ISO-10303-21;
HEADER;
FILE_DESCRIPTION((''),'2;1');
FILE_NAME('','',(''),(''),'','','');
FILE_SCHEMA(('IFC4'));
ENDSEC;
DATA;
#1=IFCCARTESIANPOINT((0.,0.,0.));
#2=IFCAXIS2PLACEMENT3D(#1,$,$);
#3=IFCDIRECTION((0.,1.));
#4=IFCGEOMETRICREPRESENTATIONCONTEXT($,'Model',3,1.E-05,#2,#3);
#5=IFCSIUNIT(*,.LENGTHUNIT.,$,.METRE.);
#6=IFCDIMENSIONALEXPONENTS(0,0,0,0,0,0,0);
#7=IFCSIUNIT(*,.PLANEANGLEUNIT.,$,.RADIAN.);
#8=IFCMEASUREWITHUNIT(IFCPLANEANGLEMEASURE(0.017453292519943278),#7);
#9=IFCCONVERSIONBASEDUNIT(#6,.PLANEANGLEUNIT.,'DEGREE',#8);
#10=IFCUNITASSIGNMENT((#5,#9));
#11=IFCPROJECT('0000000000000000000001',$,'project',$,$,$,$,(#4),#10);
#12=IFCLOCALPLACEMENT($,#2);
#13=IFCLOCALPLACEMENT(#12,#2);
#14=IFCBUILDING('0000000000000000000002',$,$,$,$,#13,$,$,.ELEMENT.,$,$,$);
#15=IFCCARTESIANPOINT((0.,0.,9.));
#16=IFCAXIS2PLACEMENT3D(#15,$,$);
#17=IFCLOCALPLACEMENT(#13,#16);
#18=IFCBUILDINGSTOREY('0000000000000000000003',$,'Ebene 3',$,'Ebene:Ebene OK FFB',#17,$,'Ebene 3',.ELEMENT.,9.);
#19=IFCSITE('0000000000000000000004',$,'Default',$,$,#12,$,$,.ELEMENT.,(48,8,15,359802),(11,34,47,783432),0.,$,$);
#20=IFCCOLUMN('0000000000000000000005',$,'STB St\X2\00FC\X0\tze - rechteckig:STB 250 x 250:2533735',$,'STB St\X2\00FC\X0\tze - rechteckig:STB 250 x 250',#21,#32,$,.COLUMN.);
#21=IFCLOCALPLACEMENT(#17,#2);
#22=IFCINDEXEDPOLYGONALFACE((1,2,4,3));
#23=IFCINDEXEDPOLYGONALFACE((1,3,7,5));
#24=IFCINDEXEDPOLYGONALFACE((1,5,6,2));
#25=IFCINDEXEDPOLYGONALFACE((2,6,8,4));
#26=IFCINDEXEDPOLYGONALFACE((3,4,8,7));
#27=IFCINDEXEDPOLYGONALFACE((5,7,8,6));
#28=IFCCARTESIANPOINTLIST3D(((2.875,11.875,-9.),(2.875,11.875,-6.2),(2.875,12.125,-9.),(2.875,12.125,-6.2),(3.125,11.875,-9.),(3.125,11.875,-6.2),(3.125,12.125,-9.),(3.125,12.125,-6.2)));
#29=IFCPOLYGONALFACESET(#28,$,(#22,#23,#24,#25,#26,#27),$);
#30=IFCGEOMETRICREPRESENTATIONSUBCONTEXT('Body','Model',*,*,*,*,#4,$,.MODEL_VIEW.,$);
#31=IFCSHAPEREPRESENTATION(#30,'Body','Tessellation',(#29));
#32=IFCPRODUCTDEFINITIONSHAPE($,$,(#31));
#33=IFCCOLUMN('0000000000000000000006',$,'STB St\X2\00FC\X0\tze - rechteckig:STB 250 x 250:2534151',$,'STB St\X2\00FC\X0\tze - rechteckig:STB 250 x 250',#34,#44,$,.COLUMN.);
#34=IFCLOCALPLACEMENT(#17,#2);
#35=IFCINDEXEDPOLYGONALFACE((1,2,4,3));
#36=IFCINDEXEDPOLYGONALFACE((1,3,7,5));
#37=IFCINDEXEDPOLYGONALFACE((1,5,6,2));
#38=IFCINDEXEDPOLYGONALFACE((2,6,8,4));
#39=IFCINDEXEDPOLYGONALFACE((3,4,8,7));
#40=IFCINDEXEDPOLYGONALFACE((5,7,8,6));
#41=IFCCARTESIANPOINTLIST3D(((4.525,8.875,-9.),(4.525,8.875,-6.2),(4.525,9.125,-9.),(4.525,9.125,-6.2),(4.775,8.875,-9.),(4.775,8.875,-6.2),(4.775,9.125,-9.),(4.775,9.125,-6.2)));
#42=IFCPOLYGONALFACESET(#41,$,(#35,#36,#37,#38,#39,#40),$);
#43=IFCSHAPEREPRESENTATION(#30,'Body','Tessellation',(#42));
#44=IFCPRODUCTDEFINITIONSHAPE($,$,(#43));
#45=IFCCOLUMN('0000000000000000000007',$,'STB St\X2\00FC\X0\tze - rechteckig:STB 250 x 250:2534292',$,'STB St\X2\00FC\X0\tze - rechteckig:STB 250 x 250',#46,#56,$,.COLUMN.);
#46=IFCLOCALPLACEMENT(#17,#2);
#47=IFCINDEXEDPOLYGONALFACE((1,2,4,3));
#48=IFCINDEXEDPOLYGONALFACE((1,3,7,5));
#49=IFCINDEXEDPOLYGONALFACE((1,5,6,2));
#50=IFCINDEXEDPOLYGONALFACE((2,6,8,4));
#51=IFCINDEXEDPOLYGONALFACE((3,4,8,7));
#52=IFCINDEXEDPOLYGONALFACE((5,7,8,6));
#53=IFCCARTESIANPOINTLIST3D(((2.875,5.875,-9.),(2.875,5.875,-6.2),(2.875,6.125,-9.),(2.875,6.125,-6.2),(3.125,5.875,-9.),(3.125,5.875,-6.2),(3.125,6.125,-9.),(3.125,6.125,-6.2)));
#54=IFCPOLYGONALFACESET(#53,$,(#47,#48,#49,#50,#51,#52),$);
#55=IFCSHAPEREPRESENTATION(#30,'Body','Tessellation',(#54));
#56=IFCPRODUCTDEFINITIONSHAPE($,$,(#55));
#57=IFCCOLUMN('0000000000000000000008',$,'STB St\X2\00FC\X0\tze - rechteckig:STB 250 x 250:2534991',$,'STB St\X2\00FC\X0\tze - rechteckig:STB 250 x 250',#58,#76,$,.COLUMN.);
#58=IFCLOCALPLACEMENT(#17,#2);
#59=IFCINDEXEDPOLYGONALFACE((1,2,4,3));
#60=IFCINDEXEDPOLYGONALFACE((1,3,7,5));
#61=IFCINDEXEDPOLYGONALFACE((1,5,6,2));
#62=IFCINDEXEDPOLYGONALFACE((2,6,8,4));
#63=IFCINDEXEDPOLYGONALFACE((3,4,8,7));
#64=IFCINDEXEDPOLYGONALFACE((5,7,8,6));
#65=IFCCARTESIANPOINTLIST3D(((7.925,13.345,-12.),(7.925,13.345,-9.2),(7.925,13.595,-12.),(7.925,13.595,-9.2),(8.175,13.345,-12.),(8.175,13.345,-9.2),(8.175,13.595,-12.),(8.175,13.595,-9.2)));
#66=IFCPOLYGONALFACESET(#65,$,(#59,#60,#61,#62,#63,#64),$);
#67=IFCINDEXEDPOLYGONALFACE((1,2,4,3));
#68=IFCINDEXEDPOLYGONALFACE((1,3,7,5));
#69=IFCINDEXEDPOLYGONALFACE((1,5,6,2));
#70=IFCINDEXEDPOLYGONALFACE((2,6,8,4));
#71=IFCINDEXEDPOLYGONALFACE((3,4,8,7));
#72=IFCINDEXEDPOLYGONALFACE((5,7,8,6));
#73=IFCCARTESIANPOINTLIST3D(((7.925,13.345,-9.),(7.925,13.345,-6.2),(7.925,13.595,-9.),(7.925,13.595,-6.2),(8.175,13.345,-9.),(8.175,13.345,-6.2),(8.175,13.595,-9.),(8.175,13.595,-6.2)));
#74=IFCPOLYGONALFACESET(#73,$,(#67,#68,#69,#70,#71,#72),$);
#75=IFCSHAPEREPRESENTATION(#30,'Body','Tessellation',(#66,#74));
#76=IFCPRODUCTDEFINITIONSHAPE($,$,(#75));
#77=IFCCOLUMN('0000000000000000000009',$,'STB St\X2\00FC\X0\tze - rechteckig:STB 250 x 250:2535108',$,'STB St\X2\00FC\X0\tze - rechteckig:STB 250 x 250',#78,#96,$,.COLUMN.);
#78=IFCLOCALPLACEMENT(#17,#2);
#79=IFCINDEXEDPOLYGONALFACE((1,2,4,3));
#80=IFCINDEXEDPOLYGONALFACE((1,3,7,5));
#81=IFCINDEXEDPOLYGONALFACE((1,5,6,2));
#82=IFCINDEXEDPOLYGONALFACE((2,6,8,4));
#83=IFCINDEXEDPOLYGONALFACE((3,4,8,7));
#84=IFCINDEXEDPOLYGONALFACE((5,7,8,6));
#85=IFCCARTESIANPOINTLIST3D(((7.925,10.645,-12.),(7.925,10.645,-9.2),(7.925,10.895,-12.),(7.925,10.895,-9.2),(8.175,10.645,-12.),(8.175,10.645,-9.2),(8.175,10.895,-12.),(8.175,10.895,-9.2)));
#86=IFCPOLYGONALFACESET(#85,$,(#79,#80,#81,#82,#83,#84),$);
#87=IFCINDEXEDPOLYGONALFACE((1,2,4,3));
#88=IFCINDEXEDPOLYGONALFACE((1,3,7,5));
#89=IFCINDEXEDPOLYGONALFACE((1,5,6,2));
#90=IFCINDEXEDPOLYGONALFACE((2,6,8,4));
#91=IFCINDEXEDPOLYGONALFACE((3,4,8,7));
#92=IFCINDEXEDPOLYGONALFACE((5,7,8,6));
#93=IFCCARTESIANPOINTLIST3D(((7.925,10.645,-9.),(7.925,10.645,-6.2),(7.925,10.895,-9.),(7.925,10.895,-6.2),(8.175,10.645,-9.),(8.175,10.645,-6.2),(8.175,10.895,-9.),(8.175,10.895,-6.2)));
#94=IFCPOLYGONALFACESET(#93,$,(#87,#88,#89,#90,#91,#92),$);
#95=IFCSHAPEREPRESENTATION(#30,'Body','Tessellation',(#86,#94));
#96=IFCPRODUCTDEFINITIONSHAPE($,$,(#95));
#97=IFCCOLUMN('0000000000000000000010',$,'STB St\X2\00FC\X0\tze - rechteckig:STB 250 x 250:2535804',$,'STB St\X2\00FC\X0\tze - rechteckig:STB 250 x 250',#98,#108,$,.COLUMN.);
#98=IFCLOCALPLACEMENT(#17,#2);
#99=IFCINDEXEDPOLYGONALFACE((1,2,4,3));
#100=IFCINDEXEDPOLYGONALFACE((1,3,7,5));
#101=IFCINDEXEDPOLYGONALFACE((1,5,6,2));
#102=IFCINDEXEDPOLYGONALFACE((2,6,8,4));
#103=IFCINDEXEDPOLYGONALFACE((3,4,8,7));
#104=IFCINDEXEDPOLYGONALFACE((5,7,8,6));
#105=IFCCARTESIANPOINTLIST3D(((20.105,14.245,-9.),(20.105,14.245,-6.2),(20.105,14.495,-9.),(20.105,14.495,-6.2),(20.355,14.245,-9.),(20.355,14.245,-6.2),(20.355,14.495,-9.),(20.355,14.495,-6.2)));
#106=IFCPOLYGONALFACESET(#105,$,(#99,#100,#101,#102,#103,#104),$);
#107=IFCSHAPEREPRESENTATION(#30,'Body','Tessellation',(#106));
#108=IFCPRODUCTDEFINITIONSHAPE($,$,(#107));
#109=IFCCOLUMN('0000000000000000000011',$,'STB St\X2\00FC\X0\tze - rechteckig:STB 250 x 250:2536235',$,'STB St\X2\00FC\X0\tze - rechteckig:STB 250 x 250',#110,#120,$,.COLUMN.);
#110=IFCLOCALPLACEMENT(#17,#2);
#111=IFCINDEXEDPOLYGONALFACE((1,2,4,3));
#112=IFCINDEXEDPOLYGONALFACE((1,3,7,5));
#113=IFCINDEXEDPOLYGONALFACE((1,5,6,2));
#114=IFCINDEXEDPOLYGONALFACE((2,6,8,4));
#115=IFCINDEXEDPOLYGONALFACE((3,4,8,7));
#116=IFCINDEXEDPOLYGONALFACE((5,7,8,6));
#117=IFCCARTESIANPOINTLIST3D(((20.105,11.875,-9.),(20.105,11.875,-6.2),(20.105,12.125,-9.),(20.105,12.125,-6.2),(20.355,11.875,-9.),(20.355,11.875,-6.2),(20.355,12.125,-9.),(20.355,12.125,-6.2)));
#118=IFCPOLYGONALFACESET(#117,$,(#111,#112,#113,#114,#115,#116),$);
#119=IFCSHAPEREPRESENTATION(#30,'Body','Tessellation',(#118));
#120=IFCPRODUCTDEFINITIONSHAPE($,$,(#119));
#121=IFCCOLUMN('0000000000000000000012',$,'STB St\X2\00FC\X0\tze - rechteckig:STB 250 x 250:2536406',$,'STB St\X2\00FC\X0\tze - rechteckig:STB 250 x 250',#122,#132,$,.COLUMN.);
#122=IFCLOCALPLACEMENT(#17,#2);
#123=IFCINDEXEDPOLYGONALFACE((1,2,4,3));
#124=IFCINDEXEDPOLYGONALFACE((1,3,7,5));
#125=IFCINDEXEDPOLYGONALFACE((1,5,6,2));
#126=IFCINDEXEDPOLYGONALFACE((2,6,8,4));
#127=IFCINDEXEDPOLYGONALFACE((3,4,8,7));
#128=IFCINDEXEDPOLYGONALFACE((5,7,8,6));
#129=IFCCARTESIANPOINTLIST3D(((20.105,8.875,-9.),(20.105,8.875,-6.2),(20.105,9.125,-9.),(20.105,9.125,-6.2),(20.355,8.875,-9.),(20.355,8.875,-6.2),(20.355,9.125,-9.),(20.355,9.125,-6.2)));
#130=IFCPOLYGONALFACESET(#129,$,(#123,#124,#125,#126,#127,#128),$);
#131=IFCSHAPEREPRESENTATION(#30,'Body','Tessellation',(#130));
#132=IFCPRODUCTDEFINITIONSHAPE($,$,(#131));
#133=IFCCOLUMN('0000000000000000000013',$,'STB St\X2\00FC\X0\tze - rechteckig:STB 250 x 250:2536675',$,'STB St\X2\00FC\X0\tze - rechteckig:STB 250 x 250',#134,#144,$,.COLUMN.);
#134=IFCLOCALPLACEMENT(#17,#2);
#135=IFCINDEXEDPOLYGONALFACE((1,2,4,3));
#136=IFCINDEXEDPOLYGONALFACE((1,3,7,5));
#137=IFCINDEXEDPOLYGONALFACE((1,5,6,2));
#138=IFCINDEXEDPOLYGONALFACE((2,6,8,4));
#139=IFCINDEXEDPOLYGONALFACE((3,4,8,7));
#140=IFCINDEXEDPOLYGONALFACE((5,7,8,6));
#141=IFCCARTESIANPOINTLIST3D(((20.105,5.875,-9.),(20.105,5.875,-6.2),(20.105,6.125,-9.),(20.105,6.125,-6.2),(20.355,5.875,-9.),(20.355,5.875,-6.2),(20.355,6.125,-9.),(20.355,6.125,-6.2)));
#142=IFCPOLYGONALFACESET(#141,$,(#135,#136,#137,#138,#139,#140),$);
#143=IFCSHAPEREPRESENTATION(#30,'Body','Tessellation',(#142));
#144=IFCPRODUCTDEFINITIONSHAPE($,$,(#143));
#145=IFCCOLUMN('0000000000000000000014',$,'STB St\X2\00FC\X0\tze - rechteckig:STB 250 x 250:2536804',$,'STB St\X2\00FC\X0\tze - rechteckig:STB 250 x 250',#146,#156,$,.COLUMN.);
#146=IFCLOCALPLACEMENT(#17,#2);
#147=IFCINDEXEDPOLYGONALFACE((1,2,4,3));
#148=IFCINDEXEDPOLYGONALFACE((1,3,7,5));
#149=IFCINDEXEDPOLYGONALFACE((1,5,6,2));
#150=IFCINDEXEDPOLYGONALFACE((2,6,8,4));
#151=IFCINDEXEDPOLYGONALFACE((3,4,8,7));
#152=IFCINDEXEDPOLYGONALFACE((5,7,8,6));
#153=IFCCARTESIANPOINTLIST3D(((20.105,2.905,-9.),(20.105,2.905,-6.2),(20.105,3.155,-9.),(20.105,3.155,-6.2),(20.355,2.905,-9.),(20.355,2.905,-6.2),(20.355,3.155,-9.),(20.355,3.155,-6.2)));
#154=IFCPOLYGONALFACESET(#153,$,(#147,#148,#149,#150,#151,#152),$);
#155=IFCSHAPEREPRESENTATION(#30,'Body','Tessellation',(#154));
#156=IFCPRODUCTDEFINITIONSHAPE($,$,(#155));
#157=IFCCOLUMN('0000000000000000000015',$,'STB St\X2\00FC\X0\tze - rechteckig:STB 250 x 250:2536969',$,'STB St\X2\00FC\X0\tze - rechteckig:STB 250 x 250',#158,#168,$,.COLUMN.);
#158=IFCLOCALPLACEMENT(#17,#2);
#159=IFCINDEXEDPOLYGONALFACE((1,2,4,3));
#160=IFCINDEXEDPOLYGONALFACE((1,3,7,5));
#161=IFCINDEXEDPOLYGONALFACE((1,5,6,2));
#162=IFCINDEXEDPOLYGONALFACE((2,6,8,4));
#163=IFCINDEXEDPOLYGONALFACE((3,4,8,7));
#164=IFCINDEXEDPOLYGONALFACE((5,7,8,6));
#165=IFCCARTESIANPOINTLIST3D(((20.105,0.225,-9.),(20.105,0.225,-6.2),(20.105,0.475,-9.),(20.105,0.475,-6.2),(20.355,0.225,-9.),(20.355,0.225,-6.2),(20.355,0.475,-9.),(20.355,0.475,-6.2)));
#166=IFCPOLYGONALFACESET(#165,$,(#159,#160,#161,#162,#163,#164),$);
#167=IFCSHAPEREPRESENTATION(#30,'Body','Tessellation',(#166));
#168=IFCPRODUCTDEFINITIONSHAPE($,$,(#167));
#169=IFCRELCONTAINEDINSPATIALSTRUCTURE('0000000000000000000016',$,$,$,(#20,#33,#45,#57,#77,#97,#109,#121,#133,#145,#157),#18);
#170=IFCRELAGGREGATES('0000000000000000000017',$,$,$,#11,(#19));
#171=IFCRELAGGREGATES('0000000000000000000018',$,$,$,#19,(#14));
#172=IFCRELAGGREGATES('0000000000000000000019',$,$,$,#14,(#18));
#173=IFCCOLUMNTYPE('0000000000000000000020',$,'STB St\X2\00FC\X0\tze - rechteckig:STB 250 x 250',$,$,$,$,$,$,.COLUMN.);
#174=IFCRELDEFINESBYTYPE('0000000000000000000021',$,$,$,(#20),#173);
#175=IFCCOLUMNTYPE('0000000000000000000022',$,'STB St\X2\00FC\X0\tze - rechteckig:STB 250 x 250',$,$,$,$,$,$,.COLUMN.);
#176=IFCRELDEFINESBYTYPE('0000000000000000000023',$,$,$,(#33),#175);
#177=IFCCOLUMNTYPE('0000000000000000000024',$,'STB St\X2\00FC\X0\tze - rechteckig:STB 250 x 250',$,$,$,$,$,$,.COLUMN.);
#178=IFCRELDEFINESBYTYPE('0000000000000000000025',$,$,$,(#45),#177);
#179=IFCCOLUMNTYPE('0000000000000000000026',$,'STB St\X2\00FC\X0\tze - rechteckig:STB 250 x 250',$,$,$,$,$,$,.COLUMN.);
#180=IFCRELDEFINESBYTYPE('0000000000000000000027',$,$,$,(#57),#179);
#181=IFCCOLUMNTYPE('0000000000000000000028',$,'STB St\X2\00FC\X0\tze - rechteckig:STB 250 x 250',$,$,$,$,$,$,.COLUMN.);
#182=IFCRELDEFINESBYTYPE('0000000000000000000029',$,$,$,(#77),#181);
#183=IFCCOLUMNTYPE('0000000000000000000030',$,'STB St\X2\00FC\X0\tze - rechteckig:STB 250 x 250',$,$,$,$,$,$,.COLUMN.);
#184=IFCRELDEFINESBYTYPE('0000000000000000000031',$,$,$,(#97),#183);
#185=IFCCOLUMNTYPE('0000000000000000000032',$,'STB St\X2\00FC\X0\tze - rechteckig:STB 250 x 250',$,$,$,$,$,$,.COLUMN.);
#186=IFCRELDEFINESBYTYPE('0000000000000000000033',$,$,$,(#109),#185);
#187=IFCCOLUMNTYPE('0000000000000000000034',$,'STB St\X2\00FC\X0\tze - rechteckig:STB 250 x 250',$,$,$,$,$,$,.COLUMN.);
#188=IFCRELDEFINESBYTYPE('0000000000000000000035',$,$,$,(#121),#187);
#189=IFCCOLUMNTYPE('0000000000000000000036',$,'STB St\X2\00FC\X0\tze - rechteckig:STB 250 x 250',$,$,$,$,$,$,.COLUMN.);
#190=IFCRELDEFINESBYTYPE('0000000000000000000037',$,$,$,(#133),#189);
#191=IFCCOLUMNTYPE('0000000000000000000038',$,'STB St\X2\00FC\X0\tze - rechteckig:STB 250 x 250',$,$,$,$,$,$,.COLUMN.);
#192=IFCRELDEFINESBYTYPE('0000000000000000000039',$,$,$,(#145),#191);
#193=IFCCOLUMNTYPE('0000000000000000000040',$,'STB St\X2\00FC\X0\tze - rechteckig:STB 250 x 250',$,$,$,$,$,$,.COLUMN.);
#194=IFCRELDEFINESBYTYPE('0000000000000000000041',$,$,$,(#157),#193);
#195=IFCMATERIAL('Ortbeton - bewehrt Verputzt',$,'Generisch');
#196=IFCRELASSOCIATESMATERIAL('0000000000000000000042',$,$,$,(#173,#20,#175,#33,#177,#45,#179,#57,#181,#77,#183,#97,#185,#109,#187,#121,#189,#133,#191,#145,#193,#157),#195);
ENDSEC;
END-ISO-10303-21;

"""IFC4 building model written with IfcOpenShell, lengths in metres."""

from ifc_helpers import new_model, entity, si_unit, converted_unit, direction, frame, origin, place, context, subcontext, project, spatial, indexed_curve, outline, extrude, source, transform, mapped, material, type_object, type_shapes, element, save


model = new_model("IFC4")

# Units and contexts
model_context = context("Model", 3, precision=1e-05, world=origin(), true_north=direction((0.0, 1.0)))
body_context = subcontext(model_context, "Body", "Model", "MODEL_VIEW")
ifc_project = project(units=[si_unit("LENGTHUNIT", "METRE"), converted_unit("PLANEANGLEUNIT", "DEGREE", entity("IfcPlaneAngleMeasure", 0.017453292519943278), si_unit("PLANEANGLEUNIT", "RADIAN"), dimensions=[0, 0, 0, 0, 0, 0, 0])], contexts=[model_context])

# Site, building, storey
site_placement = place(None, origin())
site = spatial("IfcSite", under=ifc_project, at=site_placement, Name="Default", CompositionType="ELEMENT", RefLatitude=(48, 8, 15, 359802), RefLongitude=(11, 34, 47, 783432), RefElevation=0.0)
building_placement = place(site_placement, origin())
building = spatial("IfcBuilding", under=site, at=building_placement, CompositionType="ELEMENT")
storey_placement = place(building_placement, frame((0.0, 0.0, 9.0)))
storey = spatial("IfcBuildingStorey", under=building, at=storey_placement, Name="Ebene 3", ObjectType="Ebene:Ebene OK FFB", LongName="Ebene 3", CompositionType="ELEMENT", Elevation=9.0)

# Columns
ifc_material_1 = material(Name="Ortbeton - bewehrt Verputzt", Category="Generisch")
column_type_1 = type_object("IfcColumnType", Name="STB Stütze - rechteckig:STB 250 x 250", PredefinedType="COLUMN", material=ifc_material_1)
shared_shape_1 = source(origin(), body_context, "Body", "SweptSolid", [
    extrude(outline(indexed_curve([(-0.125, -0.125), (0.125, -0.125), (0.125, 0.125), (-0.125, 0.125), (-0.125, -0.125)], self_intersect=False)), frame((3.0, 12.0, 0.0), z_axis=(0.0, 0.0, 1.0), x_axis=(-1.0, 0.0, 0.0)), (0.0, 0.0, 1.0), 2.8),
])
type_shapes(column_type_1, [shared_shape_1])
column_1_placement = place(storey_placement, frame((0.0, 0.0, -9.0)))
element("IfcColumn", 1, at=column_1_placement, inside=storey, type_object=column_type_1, material=ifc_material_1, Name="STB Stütze - rechteckig:STB 250 x 250:2533735", ObjectType="STB Stütze - rechteckig:STB 250 x 250", PredefinedType="COLUMN", context=body_context, shape_type="MappedRepresentation", body=[
    mapped(shared_shape_1, transform((0.0, 0.0, 0.0), scale=1.0)),
])
column_type_2 = type_object("IfcColumnType", Name="STB Stütze - rechteckig:STB 250 x 250", PredefinedType="COLUMN", material=ifc_material_1)
shared_shape_2 = source(origin(), body_context, "Body", "SweptSolid", [
    extrude(outline(indexed_curve([(-0.125, -0.125), (0.125, -0.125), (0.125, 0.125), (-0.125, 0.125), (-0.125, -0.125)], self_intersect=False)), frame((4.65, 9.0, 0.0), z_axis=(0.0, 0.0, 1.0), x_axis=(-1.0, 0.0, 0.0)), (0.0, 0.0, 1.0), 2.8),
])
type_shapes(column_type_2, [shared_shape_2])
column_2_placement = place(storey_placement, frame((0.0, 0.0, -9.0)))
element("IfcColumn", 2, at=column_2_placement, inside=storey, type_object=column_type_2, material=ifc_material_1, Name="STB Stütze - rechteckig:STB 250 x 250:2534151", ObjectType="STB Stütze - rechteckig:STB 250 x 250", PredefinedType="COLUMN", context=body_context, shape_type="MappedRepresentation", body=[
    mapped(shared_shape_2, transform((0.0, 0.0, 0.0), scale=1.0)),
])
column_type_3 = type_object("IfcColumnType", Name="STB Stütze - rechteckig:STB 250 x 250", PredefinedType="COLUMN", material=ifc_material_1)
shared_shape_3 = source(origin(), body_context, "Body", "SweptSolid", [
    extrude(outline(indexed_curve([(-0.125, -0.125), (0.125, -0.125), (0.125, 0.125), (-0.125, 0.125), (-0.125, -0.125)], self_intersect=False)), frame((3.0, 6.0, 0.0), z_axis=(0.0, 0.0, 1.0), x_axis=(-1.0, 0.0, 0.0)), (0.0, 0.0, 1.0), 2.8),
])
type_shapes(column_type_3, [shared_shape_3])
column_3_placement = place(storey_placement, frame((0.0, 0.0, -9.0)))
element("IfcColumn", 3, at=column_3_placement, inside=storey, type_object=column_type_3, material=ifc_material_1, Name="STB Stütze - rechteckig:STB 250 x 250:2534292", ObjectType="STB Stütze - rechteckig:STB 250 x 250", PredefinedType="COLUMN", context=body_context, shape_type="MappedRepresentation", body=[
    mapped(shared_shape_3, transform((0.0, 0.0, 0.0), scale=1.0)),
])
column_type_4 = type_object("IfcColumnType", Name="STB Stütze - rechteckig:STB 250 x 250", PredefinedType="COLUMN", material=ifc_material_1)
shared_shape_4 = source(origin(), body_context, "Body", "SweptSolid", [
    extrude(outline(indexed_curve([(-0.125, -0.125), (0.125, -0.125), (0.125, 0.125), (-0.125, 0.125), (-0.125, -0.125)], self_intersect=False)), frame((8.05, 13.47, -3.0), z_axis=(0.0, 0.0, 1.0), x_axis=(-1.0, 0.0, 0.0)), (0.0, 0.0, 1.0), 2.8),
    extrude(outline(indexed_curve([(-0.125, -0.125), (0.125, -0.125), (0.125, 0.125), (-0.125, 0.125), (-0.125, -0.125)], self_intersect=False)), frame((8.05, 13.47, 0.0), z_axis=(0.0, 0.0, 1.0), x_axis=(0.0, -1.0, 0.0)), (0.0, 0.0, 1.0), 2.8),
])
type_shapes(column_type_4, [shared_shape_4])
column_4_placement = place(storey_placement, frame((0.0, 0.0, -9.0)))
element("IfcColumn", 4, at=column_4_placement, inside=storey, type_object=column_type_4, material=ifc_material_1, Name="STB Stütze - rechteckig:STB 250 x 250:2534991", ObjectType="STB Stütze - rechteckig:STB 250 x 250", PredefinedType="COLUMN", context=body_context, shape_type="MappedRepresentation", body=[
    mapped(shared_shape_4, transform((0.0, 0.0, 0.0), scale=1.0)),
])
column_type_5 = type_object("IfcColumnType", Name="STB Stütze - rechteckig:STB 250 x 250", PredefinedType="COLUMN", material=ifc_material_1)
shared_shape_5 = source(origin(), body_context, "Body", "SweptSolid", [
    extrude(outline(indexed_curve([(-0.125, -0.125), (0.125, -0.125), (0.125, 0.125), (-0.125, 0.125), (-0.125, -0.125)], self_intersect=False)), frame((8.05, 10.77, -3.0), z_axis=(0.0, 0.0, 1.0), x_axis=(-1.0, 0.0, 0.0)), (0.0, 0.0, 1.0), 2.8),
    extrude(outline(indexed_curve([(-0.125, -0.125), (0.125, -0.125), (0.125, 0.125), (-0.125, 0.125), (-0.125, -0.125)], self_intersect=False)), frame((8.05, 10.77, 0.0), z_axis=(0.0, 0.0, 1.0), x_axis=(0.0, -1.0, 0.0)), (0.0, 0.0, 1.0), 2.8),
])
type_shapes(column_type_5, [shared_shape_5])
column_5_placement = place(storey_placement, frame((0.0, 0.0, -9.0)))
element("IfcColumn", 5, at=column_5_placement, inside=storey, type_object=column_type_5, material=ifc_material_1, Name="STB Stütze - rechteckig:STB 250 x 250:2535108", ObjectType="STB Stütze - rechteckig:STB 250 x 250", PredefinedType="COLUMN", context=body_context, shape_type="MappedRepresentation", body=[
    mapped(shared_shape_5, transform((0.0, 0.0, 0.0), scale=1.0)),
])
column_type_6 = type_object("IfcColumnType", Name="STB Stütze - rechteckig:STB 250 x 250", PredefinedType="COLUMN", material=ifc_material_1)
shared_shape_6 = source(origin(), body_context, "Body", "SweptSolid", [
    extrude(outline(indexed_curve([(-0.125, -0.125), (0.125, -0.125), (0.125, 0.125), (-0.125, 0.125), (-0.125, -0.125)], self_intersect=False)), frame((20.23, 14.37, 0.0), z_axis=(0.0, 0.0, 1.0), x_axis=(-1.0, 0.0, 0.0)), (0.0, 0.0, 1.0), 2.8),
])
type_shapes(column_type_6, [shared_shape_6])
column_6_placement = place(storey_placement, frame((0.0, 0.0, -9.0)))
element("IfcColumn", 6, at=column_6_placement, inside=storey, type_object=column_type_6, material=ifc_material_1, Name="STB Stütze - rechteckig:STB 250 x 250:2535804", ObjectType="STB Stütze - rechteckig:STB 250 x 250", PredefinedType="COLUMN", context=body_context, shape_type="MappedRepresentation", body=[
    mapped(shared_shape_6, transform((0.0, 0.0, 0.0), scale=1.0)),
])
column_type_7 = type_object("IfcColumnType", Name="STB Stütze - rechteckig:STB 250 x 250", PredefinedType="COLUMN", material=ifc_material_1)
shared_shape_7 = source(origin(), body_context, "Body", "SweptSolid", [
    extrude(outline(indexed_curve([(-0.125, -0.125), (0.125, -0.125), (0.125, 0.125), (-0.125, 0.125), (-0.125, -0.125)], self_intersect=False)), frame((20.23, 12.0, 0.0), z_axis=(0.0, 0.0, 1.0), x_axis=(-1.0, 0.0, 0.0)), (0.0, 0.0, 1.0), 2.8),
])
type_shapes(column_type_7, [shared_shape_7])
column_7_placement = place(storey_placement, frame((0.0, 0.0, -9.0)))
element("IfcColumn", 7, at=column_7_placement, inside=storey, type_object=column_type_7, material=ifc_material_1, Name="STB Stütze - rechteckig:STB 250 x 250:2536235", ObjectType="STB Stütze - rechteckig:STB 250 x 250", PredefinedType="COLUMN", context=body_context, shape_type="MappedRepresentation", body=[
    mapped(shared_shape_7, transform((0.0, 0.0, 0.0), scale=1.0)),
])
column_type_8 = type_object("IfcColumnType", Name="STB Stütze - rechteckig:STB 250 x 250", PredefinedType="COLUMN", material=ifc_material_1)
shared_shape_8 = source(origin(), body_context, "Body", "SweptSolid", [
    extrude(outline(indexed_curve([(-0.125, -0.125), (0.125, -0.125), (0.125, 0.125), (-0.125, 0.125), (-0.125, -0.125)], self_intersect=False)), frame((20.23, 9.0, 0.0), z_axis=(0.0, 0.0, 1.0), x_axis=(-1.0, 0.0, 0.0)), (0.0, 0.0, 1.0), 2.8),
])
type_shapes(column_type_8, [shared_shape_8])
column_8_placement = place(storey_placement, frame((0.0, 0.0, -9.0)))
element("IfcColumn", 8, at=column_8_placement, inside=storey, type_object=column_type_8, material=ifc_material_1, Name="STB Stütze - rechteckig:STB 250 x 250:2536406", ObjectType="STB Stütze - rechteckig:STB 250 x 250", PredefinedType="COLUMN", context=body_context, shape_type="MappedRepresentation", body=[
    mapped(shared_shape_8, transform((0.0, 0.0, 0.0), scale=1.0)),
])
column_type_9 = type_object("IfcColumnType", Name="STB Stütze - rechteckig:STB 250 x 250", PredefinedType="COLUMN", material=ifc_material_1)
shared_shape_9 = source(origin(), body_context, "Body", "SweptSolid", [
    extrude(outline(indexed_curve([(-0.125, -0.125), (0.125, -0.125), (0.125, 0.125), (-0.125, 0.125), (-0.125, -0.125)], self_intersect=False)), frame((20.23, 6.0, 0.0), z_axis=(0.0, 0.0, 1.0), x_axis=(-1.0, 0.0, 0.0)), (0.0, 0.0, 1.0), 2.8),
])
type_shapes(column_type_9, [shared_shape_9])
column_9_placement = place(storey_placement, frame((0.0, 0.0, -9.0)))
element("IfcColumn", 9, at=column_9_placement, inside=storey, type_object=column_type_9, material=ifc_material_1, Name="STB Stütze - rechteckig:STB 250 x 250:2536675", ObjectType="STB Stütze - rechteckig:STB 250 x 250", PredefinedType="COLUMN", context=body_context, shape_type="MappedRepresentation", body=[
    mapped(shared_shape_9, transform((0.0, 0.0, 0.0), scale=1.0)),
])
column_type_10 = type_object("IfcColumnType", Name="STB Stütze - rechteckig:STB 250 x 250", PredefinedType="COLUMN", material=ifc_material_1)
shared_shape_10 = source(origin(), body_context, "Body", "SweptSolid", [
    extrude(outline(indexed_curve([(-0.125, -0.125), (0.125, -0.125), (0.125, 0.125), (-0.125, 0.125), (-0.125, -0.125)], self_intersect=False)), frame((20.23, 3.03, 0.0), z_axis=(0.0, 0.0, 1.0), x_axis=(-1.0, 0.0, 0.0)), (0.0, 0.0, 1.0), 2.8),
])
type_shapes(column_type_10, [shared_shape_10])
column_10_placement = place(storey_placement, frame((0.0, 0.0, -9.0)))
element("IfcColumn", 10, at=column_10_placement, inside=storey, type_object=column_type_10, material=ifc_material_1, Name="STB Stütze - rechteckig:STB 250 x 250:2536804", ObjectType="STB Stütze - rechteckig:STB 250 x 250", PredefinedType="COLUMN", context=body_context, shape_type="MappedRepresentation", body=[
    mapped(shared_shape_10, transform((0.0, 0.0, 0.0), scale=1.0)),
])
column_type_11 = type_object("IfcColumnType", Name="STB Stütze - rechteckig:STB 250 x 250", PredefinedType="COLUMN", material=ifc_material_1)
shared_shape_11 = source(origin(), body_context, "Body", "SweptSolid", [
    extrude(outline(indexed_curve([(-0.125, -0.125), (0.125, -0.125), (0.125, 0.125), (-0.125, 0.125), (-0.125, -0.125)], self_intersect=False)), frame((20.23, 0.35, 0.0), z_axis=(0.0, 0.0, 1.0), x_axis=(-1.0, 0.0, 0.0)), (0.0, 0.0, 1.0), 2.8),
])
type_shapes(column_type_11, [shared_shape_11])
column_11_placement = place(storey_placement, frame((0.0, 0.0, -9.0)))
element("IfcColumn", 11, at=column_11_placement, inside=storey, type_object=column_type_11, material=ifc_material_1, Name="STB Stütze - rechteckig:STB 250 x 250:2536969", ObjectType="STB Stütze - rechteckig:STB 250 x 250", PredefinedType="COLUMN", context=body_context, shape_type="MappedRepresentation", body=[
    mapped(shared_shape_11, transform((0.0, 0.0, 0.0), scale=1.0)),
])

save(model, "model.ifc")
